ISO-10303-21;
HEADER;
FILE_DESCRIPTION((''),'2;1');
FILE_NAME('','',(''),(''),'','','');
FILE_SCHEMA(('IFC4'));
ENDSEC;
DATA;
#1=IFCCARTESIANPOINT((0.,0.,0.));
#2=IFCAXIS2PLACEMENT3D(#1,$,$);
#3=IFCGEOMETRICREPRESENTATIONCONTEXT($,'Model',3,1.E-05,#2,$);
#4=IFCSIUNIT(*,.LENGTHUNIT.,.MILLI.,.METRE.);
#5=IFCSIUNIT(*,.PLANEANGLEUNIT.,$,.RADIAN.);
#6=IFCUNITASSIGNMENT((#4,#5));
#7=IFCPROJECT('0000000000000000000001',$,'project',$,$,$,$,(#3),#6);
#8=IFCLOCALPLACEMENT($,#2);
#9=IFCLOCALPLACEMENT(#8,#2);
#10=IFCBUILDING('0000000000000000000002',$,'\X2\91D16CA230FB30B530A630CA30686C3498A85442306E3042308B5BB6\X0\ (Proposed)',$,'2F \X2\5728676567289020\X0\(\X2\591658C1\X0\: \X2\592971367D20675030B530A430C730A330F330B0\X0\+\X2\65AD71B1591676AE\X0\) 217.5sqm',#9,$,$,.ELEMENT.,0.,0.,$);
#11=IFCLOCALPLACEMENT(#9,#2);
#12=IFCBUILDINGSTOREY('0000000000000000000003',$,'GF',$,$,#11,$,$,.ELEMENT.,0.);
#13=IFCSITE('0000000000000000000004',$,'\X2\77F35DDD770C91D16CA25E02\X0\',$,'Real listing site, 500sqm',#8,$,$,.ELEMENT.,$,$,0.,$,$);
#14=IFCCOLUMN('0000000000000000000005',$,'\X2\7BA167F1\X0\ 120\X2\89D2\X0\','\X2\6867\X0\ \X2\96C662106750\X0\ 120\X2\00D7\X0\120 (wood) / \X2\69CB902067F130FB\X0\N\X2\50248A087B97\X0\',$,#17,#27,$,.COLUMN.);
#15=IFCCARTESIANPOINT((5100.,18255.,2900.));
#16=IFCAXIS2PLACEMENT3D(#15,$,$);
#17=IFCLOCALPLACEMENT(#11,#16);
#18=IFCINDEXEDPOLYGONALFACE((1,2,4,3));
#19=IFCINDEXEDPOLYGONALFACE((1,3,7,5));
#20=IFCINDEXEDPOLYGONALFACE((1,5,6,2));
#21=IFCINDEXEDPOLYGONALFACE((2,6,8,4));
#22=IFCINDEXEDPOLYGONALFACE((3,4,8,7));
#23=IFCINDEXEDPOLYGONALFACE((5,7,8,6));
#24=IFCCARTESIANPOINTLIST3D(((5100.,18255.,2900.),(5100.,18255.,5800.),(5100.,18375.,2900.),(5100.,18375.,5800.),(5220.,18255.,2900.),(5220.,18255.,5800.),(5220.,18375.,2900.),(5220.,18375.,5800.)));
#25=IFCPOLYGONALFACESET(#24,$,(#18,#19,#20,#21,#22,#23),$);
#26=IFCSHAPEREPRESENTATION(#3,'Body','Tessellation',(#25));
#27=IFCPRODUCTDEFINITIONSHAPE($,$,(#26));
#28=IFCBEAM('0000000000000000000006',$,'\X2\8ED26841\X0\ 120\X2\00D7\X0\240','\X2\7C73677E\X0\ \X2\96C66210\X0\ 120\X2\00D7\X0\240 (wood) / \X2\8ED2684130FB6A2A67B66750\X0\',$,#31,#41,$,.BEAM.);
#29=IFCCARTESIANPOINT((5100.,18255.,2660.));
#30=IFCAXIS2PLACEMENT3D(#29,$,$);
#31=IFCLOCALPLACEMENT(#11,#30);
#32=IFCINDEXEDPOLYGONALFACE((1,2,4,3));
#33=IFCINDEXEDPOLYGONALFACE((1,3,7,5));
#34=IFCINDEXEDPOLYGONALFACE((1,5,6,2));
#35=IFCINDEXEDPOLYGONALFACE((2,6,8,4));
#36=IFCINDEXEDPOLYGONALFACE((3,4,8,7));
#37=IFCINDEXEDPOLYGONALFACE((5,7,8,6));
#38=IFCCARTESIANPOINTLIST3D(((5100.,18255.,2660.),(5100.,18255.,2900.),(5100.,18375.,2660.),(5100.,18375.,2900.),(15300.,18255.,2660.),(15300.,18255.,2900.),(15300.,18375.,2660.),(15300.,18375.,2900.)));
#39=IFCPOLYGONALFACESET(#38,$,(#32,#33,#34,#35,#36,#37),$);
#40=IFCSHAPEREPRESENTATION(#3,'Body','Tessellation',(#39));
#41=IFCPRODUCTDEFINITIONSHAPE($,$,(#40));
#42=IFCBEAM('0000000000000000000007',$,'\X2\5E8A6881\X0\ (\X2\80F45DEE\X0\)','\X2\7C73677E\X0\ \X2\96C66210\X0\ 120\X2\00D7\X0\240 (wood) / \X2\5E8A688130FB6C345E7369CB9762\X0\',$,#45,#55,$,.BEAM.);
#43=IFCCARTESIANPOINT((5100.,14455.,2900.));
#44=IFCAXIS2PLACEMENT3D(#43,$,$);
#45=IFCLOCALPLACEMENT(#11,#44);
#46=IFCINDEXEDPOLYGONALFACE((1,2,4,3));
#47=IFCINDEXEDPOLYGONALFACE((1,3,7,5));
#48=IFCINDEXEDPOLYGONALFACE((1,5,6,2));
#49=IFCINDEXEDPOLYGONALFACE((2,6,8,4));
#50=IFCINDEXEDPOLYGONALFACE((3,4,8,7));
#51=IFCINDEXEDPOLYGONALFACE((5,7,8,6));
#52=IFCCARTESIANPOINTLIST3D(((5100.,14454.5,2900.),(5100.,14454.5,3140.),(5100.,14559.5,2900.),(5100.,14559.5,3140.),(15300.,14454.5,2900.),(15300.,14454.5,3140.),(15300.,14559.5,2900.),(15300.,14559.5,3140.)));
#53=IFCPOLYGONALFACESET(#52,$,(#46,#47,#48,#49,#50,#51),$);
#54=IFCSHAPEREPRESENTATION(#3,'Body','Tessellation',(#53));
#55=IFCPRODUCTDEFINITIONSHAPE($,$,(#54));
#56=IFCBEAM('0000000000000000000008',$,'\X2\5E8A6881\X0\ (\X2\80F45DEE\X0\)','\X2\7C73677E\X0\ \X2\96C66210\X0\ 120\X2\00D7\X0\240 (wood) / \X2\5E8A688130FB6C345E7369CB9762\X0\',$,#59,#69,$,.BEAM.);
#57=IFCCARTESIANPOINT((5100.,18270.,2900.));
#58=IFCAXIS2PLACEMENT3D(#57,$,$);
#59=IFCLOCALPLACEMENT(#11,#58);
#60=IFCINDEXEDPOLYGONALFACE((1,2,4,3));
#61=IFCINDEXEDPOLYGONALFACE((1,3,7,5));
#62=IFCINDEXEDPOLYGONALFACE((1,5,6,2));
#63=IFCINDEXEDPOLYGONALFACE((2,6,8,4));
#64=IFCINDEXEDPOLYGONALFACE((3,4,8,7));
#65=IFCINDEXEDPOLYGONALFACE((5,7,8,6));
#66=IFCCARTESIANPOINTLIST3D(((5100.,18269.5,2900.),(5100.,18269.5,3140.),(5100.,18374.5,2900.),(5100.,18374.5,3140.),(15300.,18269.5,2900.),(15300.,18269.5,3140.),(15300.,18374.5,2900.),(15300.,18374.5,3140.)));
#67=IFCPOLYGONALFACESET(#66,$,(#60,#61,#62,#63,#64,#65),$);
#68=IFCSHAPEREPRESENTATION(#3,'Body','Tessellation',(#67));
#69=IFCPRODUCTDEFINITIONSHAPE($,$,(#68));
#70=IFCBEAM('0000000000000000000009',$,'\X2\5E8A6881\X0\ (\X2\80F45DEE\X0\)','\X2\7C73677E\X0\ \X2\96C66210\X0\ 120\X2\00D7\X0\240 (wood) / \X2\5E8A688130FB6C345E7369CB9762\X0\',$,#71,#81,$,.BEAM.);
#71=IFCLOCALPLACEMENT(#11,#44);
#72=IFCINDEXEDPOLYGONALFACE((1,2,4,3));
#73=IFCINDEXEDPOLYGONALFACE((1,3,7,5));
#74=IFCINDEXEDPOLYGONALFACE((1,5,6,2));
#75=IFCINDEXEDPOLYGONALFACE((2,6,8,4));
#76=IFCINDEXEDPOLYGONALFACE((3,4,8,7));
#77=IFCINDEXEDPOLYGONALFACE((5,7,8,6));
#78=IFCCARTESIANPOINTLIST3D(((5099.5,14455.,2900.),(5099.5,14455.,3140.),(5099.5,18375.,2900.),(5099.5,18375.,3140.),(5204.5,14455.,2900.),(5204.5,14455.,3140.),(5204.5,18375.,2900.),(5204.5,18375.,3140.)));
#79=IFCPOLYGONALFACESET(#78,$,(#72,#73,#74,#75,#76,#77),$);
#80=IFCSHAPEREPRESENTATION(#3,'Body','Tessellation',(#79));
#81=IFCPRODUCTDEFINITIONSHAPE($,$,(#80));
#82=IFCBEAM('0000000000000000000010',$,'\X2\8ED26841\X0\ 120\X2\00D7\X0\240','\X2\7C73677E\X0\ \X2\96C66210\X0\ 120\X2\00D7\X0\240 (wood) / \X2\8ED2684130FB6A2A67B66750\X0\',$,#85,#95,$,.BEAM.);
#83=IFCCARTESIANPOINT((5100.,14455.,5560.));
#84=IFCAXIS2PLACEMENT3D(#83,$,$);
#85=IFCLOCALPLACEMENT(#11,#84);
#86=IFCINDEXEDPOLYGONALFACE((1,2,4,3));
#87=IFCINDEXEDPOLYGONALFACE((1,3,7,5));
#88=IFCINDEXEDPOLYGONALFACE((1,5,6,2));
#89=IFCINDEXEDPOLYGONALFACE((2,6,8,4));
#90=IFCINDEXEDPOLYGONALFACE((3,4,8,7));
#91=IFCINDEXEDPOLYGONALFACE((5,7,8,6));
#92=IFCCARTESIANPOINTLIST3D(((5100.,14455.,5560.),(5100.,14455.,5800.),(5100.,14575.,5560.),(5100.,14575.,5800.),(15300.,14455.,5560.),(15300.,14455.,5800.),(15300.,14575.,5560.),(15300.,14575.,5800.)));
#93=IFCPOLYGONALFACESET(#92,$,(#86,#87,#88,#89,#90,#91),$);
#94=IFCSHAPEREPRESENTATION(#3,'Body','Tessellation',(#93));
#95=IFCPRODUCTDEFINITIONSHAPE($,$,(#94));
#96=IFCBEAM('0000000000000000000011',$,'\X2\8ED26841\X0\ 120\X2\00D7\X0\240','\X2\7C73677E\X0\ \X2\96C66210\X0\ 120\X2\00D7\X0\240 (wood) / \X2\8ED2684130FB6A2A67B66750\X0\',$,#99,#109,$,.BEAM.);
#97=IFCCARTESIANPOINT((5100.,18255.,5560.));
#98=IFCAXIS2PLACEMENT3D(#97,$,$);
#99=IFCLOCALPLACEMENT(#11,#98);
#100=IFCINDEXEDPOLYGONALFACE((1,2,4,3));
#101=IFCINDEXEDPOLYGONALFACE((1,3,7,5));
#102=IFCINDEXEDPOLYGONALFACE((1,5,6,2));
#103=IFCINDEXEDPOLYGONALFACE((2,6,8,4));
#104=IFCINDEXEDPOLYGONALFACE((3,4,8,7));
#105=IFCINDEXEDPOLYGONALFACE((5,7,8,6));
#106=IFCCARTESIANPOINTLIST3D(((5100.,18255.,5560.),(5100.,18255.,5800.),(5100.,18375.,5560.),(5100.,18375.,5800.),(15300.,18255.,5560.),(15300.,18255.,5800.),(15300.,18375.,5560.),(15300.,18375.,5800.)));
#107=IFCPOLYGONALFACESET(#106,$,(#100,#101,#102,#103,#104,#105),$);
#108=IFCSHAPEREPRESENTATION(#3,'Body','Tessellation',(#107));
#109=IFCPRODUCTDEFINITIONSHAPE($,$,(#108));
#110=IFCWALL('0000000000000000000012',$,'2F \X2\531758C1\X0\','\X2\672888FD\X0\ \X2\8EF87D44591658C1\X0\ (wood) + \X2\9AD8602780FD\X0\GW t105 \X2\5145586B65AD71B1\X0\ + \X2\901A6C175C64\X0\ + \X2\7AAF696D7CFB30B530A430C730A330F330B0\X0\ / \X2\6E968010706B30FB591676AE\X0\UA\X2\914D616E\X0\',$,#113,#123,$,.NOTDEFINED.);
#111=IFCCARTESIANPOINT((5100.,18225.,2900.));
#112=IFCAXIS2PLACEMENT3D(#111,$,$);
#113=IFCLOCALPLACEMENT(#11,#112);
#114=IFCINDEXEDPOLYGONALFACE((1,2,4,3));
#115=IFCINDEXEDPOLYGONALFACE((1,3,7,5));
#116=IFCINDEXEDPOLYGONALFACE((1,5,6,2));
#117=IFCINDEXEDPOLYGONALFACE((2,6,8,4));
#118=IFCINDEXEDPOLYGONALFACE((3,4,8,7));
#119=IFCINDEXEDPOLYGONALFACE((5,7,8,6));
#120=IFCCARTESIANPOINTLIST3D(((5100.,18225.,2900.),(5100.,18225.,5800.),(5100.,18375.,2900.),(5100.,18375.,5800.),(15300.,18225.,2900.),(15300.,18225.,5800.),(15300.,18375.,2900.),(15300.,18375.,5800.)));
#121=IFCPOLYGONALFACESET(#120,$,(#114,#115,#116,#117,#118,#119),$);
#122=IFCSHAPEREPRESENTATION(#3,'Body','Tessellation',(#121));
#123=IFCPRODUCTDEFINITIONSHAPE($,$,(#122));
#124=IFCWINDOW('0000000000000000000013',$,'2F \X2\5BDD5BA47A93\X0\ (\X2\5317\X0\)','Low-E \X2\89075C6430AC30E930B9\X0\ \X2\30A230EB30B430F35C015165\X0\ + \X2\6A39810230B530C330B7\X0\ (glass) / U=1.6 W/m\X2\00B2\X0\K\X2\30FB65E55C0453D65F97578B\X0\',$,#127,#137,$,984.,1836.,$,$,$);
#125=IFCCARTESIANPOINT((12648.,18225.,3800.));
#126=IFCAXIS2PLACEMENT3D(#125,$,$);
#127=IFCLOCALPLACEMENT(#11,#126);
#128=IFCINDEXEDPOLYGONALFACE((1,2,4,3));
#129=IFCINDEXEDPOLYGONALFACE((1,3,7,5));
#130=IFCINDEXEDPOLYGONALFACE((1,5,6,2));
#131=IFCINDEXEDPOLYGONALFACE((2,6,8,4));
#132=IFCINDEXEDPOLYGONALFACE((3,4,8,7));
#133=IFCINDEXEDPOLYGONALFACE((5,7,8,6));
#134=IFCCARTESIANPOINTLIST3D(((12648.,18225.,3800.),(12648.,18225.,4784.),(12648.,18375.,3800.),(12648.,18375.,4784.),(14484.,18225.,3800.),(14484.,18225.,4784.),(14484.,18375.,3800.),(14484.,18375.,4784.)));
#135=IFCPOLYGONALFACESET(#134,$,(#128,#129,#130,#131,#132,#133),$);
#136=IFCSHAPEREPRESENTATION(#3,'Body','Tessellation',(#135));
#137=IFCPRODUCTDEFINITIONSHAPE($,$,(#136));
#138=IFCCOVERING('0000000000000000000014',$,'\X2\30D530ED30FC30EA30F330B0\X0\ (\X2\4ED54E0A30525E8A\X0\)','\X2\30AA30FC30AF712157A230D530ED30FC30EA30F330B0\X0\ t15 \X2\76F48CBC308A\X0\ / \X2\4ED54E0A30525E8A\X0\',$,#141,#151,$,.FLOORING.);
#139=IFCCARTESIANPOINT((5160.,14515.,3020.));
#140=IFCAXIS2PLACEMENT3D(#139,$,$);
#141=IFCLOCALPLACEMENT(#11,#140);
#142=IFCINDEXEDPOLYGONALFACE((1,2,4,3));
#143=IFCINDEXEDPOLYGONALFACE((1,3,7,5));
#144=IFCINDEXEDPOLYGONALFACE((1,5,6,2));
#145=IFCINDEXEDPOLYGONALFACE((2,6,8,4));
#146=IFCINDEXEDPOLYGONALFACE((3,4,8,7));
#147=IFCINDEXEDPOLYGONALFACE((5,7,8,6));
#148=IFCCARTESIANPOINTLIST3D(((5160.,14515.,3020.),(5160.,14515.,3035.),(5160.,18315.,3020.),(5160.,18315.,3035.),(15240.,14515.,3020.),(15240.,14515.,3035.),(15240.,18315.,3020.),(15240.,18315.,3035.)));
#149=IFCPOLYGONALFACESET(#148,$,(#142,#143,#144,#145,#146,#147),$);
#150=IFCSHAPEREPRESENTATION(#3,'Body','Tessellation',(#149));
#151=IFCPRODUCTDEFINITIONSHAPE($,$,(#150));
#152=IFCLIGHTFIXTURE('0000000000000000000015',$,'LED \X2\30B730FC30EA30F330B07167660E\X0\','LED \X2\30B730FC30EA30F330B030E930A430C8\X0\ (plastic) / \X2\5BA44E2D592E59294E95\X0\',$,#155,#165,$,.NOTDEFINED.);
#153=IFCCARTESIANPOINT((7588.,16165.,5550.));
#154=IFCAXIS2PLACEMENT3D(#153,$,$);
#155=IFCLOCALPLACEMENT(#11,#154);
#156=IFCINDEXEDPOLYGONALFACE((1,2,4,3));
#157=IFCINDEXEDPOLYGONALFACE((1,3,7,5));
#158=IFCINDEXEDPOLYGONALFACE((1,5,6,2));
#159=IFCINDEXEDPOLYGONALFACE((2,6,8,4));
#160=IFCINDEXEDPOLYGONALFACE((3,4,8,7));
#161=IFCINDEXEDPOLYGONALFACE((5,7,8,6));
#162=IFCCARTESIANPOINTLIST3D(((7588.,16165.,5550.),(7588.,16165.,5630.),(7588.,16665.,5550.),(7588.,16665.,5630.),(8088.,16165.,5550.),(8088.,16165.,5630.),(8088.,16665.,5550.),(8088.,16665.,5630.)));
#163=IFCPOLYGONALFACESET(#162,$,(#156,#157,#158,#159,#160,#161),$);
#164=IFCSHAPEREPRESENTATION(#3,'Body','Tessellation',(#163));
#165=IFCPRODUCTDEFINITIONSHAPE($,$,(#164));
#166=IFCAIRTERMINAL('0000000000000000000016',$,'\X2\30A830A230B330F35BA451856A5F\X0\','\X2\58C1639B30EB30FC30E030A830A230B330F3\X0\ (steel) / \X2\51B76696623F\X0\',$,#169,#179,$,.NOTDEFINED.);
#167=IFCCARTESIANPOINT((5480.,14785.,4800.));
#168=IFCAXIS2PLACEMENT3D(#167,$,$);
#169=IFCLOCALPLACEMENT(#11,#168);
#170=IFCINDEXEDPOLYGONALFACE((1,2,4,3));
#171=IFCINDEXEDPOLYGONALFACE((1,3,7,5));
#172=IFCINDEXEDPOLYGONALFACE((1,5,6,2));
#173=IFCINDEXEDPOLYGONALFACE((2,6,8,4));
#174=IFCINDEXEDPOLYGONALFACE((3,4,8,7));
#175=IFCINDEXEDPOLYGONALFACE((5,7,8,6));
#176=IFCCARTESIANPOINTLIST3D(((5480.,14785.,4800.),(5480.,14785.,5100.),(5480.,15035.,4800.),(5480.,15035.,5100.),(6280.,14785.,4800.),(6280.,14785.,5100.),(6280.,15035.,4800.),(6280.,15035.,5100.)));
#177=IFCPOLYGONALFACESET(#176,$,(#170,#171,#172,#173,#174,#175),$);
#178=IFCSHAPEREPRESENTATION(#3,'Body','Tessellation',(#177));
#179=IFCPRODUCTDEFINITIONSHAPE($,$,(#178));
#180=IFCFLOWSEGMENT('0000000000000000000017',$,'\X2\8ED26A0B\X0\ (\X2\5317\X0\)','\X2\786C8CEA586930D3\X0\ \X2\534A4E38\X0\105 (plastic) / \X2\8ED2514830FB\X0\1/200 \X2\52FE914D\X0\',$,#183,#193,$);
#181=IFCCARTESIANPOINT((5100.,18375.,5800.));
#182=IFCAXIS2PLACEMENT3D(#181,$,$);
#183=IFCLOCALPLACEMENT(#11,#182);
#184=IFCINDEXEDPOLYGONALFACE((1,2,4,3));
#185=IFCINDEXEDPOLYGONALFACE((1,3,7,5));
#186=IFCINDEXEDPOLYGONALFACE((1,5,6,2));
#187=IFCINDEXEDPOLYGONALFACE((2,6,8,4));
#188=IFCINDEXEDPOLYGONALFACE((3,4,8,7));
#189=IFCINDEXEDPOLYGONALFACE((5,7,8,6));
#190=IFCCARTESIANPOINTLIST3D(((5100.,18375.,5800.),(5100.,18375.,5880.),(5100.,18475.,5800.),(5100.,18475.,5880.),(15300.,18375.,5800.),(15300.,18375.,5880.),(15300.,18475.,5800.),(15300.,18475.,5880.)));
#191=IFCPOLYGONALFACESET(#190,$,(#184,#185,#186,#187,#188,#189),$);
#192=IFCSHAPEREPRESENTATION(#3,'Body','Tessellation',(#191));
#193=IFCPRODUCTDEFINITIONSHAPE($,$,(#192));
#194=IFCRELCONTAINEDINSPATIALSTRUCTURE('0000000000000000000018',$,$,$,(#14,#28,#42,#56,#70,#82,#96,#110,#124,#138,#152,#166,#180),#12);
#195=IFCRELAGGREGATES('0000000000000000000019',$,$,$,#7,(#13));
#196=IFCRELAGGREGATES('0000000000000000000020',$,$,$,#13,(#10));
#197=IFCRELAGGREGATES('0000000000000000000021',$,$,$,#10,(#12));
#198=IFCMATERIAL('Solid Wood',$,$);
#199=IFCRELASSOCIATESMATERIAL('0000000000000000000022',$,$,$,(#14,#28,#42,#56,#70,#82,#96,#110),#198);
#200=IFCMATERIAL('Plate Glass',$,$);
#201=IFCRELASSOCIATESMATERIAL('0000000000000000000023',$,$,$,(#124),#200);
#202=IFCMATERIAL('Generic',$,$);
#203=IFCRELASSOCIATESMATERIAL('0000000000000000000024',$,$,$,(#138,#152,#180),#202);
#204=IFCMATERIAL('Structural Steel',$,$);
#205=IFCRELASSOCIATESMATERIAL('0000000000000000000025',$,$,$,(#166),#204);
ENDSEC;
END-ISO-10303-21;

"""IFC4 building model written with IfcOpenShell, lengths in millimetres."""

from ifc_helpers import new_model, si_unit, frame, frame_2d, origin, place, context, project, spatial, rectangle, extrude, material, element, fill, save


model = new_model("IFC4")

# Units and contexts
model_context = context("Model", 3, precision=1e-05, world=origin())
ifc_project = project(units=[si_unit("LENGTHUNIT", "METRE", prefix="MILLI"), si_unit("PLANEANGLEUNIT", "RADIAN")], contexts=[model_context])

# Site, building, storey
site_placement = place(None, origin())
site = spatial("IfcSite", under=ifc_project, at=site_placement, Name="石川県金沢市", ObjectType="Real listing site, 500sqm", CompositionType="ELEMENT", RefElevation=0.0)
building_placement = place(site_placement, origin())
building = spatial("IfcBuilding", under=site, at=building_placement, Name="金沢・サウナと水風呂のある家 (Proposed)", ObjectType="2F 在来木造(外壁: 天然素材サイディング+断熱外皮) 217.5sqm", CompositionType="ELEMENT", ElevationOfRefHeight=0.0, ElevationOfTerrain=0.0)
storey_placement = place(building_placement, origin())
storey = spatial("IfcBuildingStorey", under=building, at=storey_placement, Name="GF", CompositionType="ELEMENT", Elevation=0.0)

# Column
ifc_material_1 = material(Name="Solid Wood")
column_1_placement = place(storey_placement, frame((5100.0, 18255.0, 2900.0)))
element("IfcColumn", 1, at=column_1_placement, inside=storey, material=ifc_material_1, Name="管柱 120角", Description="桧 集成材 120×120 (wood) / 構造柱・N値計算", PredefinedType="COLUMN", context=model_context, shape_type="SweptSolid", body=[
    extrude(rectangle(XDim=120.0, YDim=120.0, at=frame_2d((60.0, 60.0))), frame((5100.0, 18255.0, 2900.0)), (0.0, 0.0, 1.0), 2900.0),
])

# Beams
beam_1_placement = place(storey_placement, frame((5100.0, 18255.0, 2660.0)))
element("IfcBeam", 2, at=beam_1_placement, inside=storey, material=ifc_material_1, Name="軒桁 120×240", Description="米松 集成 120×240 (wood) / 軒桁・横架材", PredefinedType="BEAM", context=model_context, shape_type="SweptSolid", body=[
    extrude(rectangle(XDim=10200.0, YDim=120.0, at=frame_2d((5100.0, 60.0))), frame((5100.0, 18255.0, 2660.0)), (0.0, 0.0, 1.0), 240.0),
])
beam_2_placement = place(storey_placement, frame((5100.0, 14455.0, 2900.0)))
element("IfcBeam", 3, at=beam_2_placement, inside=storey, material=ifc_material_1, Name="床梁 (胴差)", Description="米松 集成 120×240 (wood) / 床梁・水平構面", PredefinedType="BEAM", context=model_context, shape_type="SweptSolid", body=[
    extrude(rectangle(XDim=10200.0, YDim=105.0, at=frame_2d((5100.0, 52.0))), frame((5100.0, 14455.0, 2900.0)), (0.0, 0.0, 1.0), 240.0),
])
beam_3_placement = place(storey_placement, frame((5100.0, 18270.0, 2900.0)))
element("IfcBeam", 4, at=beam_3_placement, inside=storey, material=ifc_material_1, Name="床梁 (胴差)", Description="米松 集成 120×240 (wood) / 床梁・水平構面", PredefinedType="BEAM", context=model_context, shape_type="SweptSolid", body=[
    extrude(rectangle(XDim=10200.0, YDim=105.0, at=frame_2d((5100.0, 52.0))), frame((5100.0, 18270.0, 2900.0)), (0.0, 0.0, 1.0), 240.0),
])
beam_4_placement = place(storey_placement, frame((5100.0, 14455.0, 2900.0)))
element("IfcBeam", 5, at=beam_4_placement, inside=storey, material=ifc_material_1, Name="床梁 (胴差)", Description="米松 集成 120×240 (wood) / 床梁・水平構面", PredefinedType="BEAM", context=model_context, shape_type="SweptSolid", body=[
    extrude(rectangle(XDim=105.0, YDim=3920.0, at=frame_2d((52.0, 1960.0))), frame((5100.0, 14455.0, 2900.0)), (0.0, 0.0, 1.0), 240.0),
])
beam_5_placement = place(storey_placement, frame((5100.0, 14455.0, 5560.0)))
element("IfcBeam", 6, at=beam_5_placement, inside=storey, material=ifc_material_1, Name="軒桁 120×240", Description="米松 集成 120×240 (wood) / 軒桁・横架材", PredefinedType="BEAM", context=model_context, shape_type="SweptSolid", body=[
    extrude(rectangle(XDim=10200.0, YDim=120.0, at=frame_2d((5100.0, 60.0))), frame((5100.0, 14455.0, 5560.0)), (0.0, 0.0, 1.0), 240.0),
])
beam_6_placement = place(storey_placement, frame((5100.0, 18255.0, 5560.0)))
element("IfcBeam", 7, at=beam_6_placement, inside=storey, material=ifc_material_1, Name="軒桁 120×240", Description="米松 集成 120×240 (wood) / 軒桁・横架材", PredefinedType="BEAM", context=model_context, shape_type="SweptSolid", body=[
    extrude(rectangle(XDim=10200.0, YDim=120.0, at=frame_2d((5100.0, 60.0))), frame((5100.0, 18255.0, 5560.0)), (0.0, 0.0, 1.0), 240.0),
])

# Wall, opening, window
wall_placement = place(storey_placement, frame((5100.0, 18225.0, 2900.0)))
wall = element("IfcWall", 8, at=wall_placement, inside=storey, material=ifc_material_1, Name="2F 北壁", Description="木製 軸組外壁 (wood) + 高性能GW t105 充填断熱 + 通気層 + 窯業系サイディング / 準耐火・外皮UA配慮", PredefinedType="NOTDEFINED", context=model_context, shape_type="SweptSolid", body=[
    extrude(rectangle(XDim=10200.0, YDim=150.0, at=frame_2d((5100.0, 75.0))), frame((5100.0, 18225.0, 2900.0)), (0.0, 0.0, 1.0), 2900.0),
])
opening_placement = place(storey_placement, frame((12648.0, 18225.0, 3800.0)))
opening = element("IfcOpeningElement", 9, at=opening_placement, cuts=wall, PredefinedType="NOTDEFINED", context=model_context, shape_type="SweptSolid", body=[
    extrude(rectangle(XDim=1836.0, YDim=150.0, at=frame_2d((918.0, 75.0))), frame((12648.0, 18225.0, 3800.0)), (0.0, 0.0, 1.0), 984.0),
])
ifc_material_2 = material(Name="Plate Glass")
window_placement = place(storey_placement, frame((12648.0, 18225.0, 3800.0)))
window = element("IfcWindow", 10, at=window_placement, inside=storey, material=ifc_material_2, Name="2F 寝室窓 (北)", Description="Low-E 複層ガラス アルゴン封入 + 樹脂サッシ (glass) / U=1.6 W/m²K・日射取得型", OverallHeight=984.0, OverallWidth=1836.0, context=model_context, shape_type="SweptSolid", body=[
    extrude(rectangle(XDim=1836.0, YDim=150.0, at=frame_2d((918.0, 75.0))), frame((12648.0, 18225.0, 3800.0)), (0.0, 0.0, 1.0), 984.0),
])
fill(opening, window)

# Covering
ifc_material_3 = material(Name="Generic")
covering_placement = place(storey_placement, frame((5160.0, 14515.0, 3020.0)))
element("IfcCovering", 11, at=covering_placement, inside=storey, material=ifc_material_3, Name="フローリング (仕上げ床)", Description="オーク無垢フローリング t15 直貼り / 仕上げ床", PredefinedType="FLOORING", context=model_context, shape_type="SweptSolid", body=[
    extrude(rectangle(XDim=10080.0, YDim=3800.0, at=frame_2d((5040.0, 1900.0))), frame((5160.0, 14515.0, 3020.0)), (0.0, 0.0, 1.0), 15.0),
])

# Light fixture
light_fixture_placement = place(storey_placement, frame((7588.0, 16165.0, 5550.0)))
element("IfcLightFixture", 12, at=light_fixture_placement, inside=storey, material=ifc_material_3, Name="LED シーリング照明", Description="LED シーリングライト (plastic) / 室中央天井", PredefinedType="NOTDEFINED", context=model_context, shape_type="SweptSolid", body=[
    extrude(rectangle(XDim=500.0, YDim=500.0, at=frame_2d((250.0, 250.0))), frame((7588.0, 16165.0, 5550.0)), (0.0, 0.0, 1.0), 80.0),
])

# Air terminal
ifc_material_4 = material(Name="Structural Steel")
air_terminal_placement = place(storey_placement, frame((5480.0, 14785.0, 4800.0)))
element("IfcAirTerminal", 13, at=air_terminal_placement, inside=storey, material=ifc_material_4, Name="エアコン室内機", Description="壁掛ルームエアコン (steel) / 冷暖房", PredefinedType="NOTDEFINED", context=model_context, shape_type="SweptSolid", body=[
    extrude(rectangle(XDim=800.0, YDim=250.0, at=frame_2d((400.0, 125.0))), frame((5480.0, 14785.0, 4800.0)), (0.0, 0.0, 1.0), 300.0),
])

# Flow segment
flow_segment_placement = place(storey_placement, frame((5100.0, 18375.0, 5800.0)))
element("IfcFlowSegment", 14, at=flow_segment_placement, inside=storey, material=ifc_material_3, Name="軒樋 (北)", Description="硬質塩ビ 半丸105 (plastic) / 軒先・1/200 勾配", context=model_context, shape_type="SweptSolid", body=[
    extrude(rectangle(XDim=10200.0, YDim=100.0, at=frame_2d((5100.0, 50.0))), frame((5100.0, 18375.0, 5800.0)), (0.0, 0.0, 1.0), 80.0),
])

save(model, "model.ifc")
